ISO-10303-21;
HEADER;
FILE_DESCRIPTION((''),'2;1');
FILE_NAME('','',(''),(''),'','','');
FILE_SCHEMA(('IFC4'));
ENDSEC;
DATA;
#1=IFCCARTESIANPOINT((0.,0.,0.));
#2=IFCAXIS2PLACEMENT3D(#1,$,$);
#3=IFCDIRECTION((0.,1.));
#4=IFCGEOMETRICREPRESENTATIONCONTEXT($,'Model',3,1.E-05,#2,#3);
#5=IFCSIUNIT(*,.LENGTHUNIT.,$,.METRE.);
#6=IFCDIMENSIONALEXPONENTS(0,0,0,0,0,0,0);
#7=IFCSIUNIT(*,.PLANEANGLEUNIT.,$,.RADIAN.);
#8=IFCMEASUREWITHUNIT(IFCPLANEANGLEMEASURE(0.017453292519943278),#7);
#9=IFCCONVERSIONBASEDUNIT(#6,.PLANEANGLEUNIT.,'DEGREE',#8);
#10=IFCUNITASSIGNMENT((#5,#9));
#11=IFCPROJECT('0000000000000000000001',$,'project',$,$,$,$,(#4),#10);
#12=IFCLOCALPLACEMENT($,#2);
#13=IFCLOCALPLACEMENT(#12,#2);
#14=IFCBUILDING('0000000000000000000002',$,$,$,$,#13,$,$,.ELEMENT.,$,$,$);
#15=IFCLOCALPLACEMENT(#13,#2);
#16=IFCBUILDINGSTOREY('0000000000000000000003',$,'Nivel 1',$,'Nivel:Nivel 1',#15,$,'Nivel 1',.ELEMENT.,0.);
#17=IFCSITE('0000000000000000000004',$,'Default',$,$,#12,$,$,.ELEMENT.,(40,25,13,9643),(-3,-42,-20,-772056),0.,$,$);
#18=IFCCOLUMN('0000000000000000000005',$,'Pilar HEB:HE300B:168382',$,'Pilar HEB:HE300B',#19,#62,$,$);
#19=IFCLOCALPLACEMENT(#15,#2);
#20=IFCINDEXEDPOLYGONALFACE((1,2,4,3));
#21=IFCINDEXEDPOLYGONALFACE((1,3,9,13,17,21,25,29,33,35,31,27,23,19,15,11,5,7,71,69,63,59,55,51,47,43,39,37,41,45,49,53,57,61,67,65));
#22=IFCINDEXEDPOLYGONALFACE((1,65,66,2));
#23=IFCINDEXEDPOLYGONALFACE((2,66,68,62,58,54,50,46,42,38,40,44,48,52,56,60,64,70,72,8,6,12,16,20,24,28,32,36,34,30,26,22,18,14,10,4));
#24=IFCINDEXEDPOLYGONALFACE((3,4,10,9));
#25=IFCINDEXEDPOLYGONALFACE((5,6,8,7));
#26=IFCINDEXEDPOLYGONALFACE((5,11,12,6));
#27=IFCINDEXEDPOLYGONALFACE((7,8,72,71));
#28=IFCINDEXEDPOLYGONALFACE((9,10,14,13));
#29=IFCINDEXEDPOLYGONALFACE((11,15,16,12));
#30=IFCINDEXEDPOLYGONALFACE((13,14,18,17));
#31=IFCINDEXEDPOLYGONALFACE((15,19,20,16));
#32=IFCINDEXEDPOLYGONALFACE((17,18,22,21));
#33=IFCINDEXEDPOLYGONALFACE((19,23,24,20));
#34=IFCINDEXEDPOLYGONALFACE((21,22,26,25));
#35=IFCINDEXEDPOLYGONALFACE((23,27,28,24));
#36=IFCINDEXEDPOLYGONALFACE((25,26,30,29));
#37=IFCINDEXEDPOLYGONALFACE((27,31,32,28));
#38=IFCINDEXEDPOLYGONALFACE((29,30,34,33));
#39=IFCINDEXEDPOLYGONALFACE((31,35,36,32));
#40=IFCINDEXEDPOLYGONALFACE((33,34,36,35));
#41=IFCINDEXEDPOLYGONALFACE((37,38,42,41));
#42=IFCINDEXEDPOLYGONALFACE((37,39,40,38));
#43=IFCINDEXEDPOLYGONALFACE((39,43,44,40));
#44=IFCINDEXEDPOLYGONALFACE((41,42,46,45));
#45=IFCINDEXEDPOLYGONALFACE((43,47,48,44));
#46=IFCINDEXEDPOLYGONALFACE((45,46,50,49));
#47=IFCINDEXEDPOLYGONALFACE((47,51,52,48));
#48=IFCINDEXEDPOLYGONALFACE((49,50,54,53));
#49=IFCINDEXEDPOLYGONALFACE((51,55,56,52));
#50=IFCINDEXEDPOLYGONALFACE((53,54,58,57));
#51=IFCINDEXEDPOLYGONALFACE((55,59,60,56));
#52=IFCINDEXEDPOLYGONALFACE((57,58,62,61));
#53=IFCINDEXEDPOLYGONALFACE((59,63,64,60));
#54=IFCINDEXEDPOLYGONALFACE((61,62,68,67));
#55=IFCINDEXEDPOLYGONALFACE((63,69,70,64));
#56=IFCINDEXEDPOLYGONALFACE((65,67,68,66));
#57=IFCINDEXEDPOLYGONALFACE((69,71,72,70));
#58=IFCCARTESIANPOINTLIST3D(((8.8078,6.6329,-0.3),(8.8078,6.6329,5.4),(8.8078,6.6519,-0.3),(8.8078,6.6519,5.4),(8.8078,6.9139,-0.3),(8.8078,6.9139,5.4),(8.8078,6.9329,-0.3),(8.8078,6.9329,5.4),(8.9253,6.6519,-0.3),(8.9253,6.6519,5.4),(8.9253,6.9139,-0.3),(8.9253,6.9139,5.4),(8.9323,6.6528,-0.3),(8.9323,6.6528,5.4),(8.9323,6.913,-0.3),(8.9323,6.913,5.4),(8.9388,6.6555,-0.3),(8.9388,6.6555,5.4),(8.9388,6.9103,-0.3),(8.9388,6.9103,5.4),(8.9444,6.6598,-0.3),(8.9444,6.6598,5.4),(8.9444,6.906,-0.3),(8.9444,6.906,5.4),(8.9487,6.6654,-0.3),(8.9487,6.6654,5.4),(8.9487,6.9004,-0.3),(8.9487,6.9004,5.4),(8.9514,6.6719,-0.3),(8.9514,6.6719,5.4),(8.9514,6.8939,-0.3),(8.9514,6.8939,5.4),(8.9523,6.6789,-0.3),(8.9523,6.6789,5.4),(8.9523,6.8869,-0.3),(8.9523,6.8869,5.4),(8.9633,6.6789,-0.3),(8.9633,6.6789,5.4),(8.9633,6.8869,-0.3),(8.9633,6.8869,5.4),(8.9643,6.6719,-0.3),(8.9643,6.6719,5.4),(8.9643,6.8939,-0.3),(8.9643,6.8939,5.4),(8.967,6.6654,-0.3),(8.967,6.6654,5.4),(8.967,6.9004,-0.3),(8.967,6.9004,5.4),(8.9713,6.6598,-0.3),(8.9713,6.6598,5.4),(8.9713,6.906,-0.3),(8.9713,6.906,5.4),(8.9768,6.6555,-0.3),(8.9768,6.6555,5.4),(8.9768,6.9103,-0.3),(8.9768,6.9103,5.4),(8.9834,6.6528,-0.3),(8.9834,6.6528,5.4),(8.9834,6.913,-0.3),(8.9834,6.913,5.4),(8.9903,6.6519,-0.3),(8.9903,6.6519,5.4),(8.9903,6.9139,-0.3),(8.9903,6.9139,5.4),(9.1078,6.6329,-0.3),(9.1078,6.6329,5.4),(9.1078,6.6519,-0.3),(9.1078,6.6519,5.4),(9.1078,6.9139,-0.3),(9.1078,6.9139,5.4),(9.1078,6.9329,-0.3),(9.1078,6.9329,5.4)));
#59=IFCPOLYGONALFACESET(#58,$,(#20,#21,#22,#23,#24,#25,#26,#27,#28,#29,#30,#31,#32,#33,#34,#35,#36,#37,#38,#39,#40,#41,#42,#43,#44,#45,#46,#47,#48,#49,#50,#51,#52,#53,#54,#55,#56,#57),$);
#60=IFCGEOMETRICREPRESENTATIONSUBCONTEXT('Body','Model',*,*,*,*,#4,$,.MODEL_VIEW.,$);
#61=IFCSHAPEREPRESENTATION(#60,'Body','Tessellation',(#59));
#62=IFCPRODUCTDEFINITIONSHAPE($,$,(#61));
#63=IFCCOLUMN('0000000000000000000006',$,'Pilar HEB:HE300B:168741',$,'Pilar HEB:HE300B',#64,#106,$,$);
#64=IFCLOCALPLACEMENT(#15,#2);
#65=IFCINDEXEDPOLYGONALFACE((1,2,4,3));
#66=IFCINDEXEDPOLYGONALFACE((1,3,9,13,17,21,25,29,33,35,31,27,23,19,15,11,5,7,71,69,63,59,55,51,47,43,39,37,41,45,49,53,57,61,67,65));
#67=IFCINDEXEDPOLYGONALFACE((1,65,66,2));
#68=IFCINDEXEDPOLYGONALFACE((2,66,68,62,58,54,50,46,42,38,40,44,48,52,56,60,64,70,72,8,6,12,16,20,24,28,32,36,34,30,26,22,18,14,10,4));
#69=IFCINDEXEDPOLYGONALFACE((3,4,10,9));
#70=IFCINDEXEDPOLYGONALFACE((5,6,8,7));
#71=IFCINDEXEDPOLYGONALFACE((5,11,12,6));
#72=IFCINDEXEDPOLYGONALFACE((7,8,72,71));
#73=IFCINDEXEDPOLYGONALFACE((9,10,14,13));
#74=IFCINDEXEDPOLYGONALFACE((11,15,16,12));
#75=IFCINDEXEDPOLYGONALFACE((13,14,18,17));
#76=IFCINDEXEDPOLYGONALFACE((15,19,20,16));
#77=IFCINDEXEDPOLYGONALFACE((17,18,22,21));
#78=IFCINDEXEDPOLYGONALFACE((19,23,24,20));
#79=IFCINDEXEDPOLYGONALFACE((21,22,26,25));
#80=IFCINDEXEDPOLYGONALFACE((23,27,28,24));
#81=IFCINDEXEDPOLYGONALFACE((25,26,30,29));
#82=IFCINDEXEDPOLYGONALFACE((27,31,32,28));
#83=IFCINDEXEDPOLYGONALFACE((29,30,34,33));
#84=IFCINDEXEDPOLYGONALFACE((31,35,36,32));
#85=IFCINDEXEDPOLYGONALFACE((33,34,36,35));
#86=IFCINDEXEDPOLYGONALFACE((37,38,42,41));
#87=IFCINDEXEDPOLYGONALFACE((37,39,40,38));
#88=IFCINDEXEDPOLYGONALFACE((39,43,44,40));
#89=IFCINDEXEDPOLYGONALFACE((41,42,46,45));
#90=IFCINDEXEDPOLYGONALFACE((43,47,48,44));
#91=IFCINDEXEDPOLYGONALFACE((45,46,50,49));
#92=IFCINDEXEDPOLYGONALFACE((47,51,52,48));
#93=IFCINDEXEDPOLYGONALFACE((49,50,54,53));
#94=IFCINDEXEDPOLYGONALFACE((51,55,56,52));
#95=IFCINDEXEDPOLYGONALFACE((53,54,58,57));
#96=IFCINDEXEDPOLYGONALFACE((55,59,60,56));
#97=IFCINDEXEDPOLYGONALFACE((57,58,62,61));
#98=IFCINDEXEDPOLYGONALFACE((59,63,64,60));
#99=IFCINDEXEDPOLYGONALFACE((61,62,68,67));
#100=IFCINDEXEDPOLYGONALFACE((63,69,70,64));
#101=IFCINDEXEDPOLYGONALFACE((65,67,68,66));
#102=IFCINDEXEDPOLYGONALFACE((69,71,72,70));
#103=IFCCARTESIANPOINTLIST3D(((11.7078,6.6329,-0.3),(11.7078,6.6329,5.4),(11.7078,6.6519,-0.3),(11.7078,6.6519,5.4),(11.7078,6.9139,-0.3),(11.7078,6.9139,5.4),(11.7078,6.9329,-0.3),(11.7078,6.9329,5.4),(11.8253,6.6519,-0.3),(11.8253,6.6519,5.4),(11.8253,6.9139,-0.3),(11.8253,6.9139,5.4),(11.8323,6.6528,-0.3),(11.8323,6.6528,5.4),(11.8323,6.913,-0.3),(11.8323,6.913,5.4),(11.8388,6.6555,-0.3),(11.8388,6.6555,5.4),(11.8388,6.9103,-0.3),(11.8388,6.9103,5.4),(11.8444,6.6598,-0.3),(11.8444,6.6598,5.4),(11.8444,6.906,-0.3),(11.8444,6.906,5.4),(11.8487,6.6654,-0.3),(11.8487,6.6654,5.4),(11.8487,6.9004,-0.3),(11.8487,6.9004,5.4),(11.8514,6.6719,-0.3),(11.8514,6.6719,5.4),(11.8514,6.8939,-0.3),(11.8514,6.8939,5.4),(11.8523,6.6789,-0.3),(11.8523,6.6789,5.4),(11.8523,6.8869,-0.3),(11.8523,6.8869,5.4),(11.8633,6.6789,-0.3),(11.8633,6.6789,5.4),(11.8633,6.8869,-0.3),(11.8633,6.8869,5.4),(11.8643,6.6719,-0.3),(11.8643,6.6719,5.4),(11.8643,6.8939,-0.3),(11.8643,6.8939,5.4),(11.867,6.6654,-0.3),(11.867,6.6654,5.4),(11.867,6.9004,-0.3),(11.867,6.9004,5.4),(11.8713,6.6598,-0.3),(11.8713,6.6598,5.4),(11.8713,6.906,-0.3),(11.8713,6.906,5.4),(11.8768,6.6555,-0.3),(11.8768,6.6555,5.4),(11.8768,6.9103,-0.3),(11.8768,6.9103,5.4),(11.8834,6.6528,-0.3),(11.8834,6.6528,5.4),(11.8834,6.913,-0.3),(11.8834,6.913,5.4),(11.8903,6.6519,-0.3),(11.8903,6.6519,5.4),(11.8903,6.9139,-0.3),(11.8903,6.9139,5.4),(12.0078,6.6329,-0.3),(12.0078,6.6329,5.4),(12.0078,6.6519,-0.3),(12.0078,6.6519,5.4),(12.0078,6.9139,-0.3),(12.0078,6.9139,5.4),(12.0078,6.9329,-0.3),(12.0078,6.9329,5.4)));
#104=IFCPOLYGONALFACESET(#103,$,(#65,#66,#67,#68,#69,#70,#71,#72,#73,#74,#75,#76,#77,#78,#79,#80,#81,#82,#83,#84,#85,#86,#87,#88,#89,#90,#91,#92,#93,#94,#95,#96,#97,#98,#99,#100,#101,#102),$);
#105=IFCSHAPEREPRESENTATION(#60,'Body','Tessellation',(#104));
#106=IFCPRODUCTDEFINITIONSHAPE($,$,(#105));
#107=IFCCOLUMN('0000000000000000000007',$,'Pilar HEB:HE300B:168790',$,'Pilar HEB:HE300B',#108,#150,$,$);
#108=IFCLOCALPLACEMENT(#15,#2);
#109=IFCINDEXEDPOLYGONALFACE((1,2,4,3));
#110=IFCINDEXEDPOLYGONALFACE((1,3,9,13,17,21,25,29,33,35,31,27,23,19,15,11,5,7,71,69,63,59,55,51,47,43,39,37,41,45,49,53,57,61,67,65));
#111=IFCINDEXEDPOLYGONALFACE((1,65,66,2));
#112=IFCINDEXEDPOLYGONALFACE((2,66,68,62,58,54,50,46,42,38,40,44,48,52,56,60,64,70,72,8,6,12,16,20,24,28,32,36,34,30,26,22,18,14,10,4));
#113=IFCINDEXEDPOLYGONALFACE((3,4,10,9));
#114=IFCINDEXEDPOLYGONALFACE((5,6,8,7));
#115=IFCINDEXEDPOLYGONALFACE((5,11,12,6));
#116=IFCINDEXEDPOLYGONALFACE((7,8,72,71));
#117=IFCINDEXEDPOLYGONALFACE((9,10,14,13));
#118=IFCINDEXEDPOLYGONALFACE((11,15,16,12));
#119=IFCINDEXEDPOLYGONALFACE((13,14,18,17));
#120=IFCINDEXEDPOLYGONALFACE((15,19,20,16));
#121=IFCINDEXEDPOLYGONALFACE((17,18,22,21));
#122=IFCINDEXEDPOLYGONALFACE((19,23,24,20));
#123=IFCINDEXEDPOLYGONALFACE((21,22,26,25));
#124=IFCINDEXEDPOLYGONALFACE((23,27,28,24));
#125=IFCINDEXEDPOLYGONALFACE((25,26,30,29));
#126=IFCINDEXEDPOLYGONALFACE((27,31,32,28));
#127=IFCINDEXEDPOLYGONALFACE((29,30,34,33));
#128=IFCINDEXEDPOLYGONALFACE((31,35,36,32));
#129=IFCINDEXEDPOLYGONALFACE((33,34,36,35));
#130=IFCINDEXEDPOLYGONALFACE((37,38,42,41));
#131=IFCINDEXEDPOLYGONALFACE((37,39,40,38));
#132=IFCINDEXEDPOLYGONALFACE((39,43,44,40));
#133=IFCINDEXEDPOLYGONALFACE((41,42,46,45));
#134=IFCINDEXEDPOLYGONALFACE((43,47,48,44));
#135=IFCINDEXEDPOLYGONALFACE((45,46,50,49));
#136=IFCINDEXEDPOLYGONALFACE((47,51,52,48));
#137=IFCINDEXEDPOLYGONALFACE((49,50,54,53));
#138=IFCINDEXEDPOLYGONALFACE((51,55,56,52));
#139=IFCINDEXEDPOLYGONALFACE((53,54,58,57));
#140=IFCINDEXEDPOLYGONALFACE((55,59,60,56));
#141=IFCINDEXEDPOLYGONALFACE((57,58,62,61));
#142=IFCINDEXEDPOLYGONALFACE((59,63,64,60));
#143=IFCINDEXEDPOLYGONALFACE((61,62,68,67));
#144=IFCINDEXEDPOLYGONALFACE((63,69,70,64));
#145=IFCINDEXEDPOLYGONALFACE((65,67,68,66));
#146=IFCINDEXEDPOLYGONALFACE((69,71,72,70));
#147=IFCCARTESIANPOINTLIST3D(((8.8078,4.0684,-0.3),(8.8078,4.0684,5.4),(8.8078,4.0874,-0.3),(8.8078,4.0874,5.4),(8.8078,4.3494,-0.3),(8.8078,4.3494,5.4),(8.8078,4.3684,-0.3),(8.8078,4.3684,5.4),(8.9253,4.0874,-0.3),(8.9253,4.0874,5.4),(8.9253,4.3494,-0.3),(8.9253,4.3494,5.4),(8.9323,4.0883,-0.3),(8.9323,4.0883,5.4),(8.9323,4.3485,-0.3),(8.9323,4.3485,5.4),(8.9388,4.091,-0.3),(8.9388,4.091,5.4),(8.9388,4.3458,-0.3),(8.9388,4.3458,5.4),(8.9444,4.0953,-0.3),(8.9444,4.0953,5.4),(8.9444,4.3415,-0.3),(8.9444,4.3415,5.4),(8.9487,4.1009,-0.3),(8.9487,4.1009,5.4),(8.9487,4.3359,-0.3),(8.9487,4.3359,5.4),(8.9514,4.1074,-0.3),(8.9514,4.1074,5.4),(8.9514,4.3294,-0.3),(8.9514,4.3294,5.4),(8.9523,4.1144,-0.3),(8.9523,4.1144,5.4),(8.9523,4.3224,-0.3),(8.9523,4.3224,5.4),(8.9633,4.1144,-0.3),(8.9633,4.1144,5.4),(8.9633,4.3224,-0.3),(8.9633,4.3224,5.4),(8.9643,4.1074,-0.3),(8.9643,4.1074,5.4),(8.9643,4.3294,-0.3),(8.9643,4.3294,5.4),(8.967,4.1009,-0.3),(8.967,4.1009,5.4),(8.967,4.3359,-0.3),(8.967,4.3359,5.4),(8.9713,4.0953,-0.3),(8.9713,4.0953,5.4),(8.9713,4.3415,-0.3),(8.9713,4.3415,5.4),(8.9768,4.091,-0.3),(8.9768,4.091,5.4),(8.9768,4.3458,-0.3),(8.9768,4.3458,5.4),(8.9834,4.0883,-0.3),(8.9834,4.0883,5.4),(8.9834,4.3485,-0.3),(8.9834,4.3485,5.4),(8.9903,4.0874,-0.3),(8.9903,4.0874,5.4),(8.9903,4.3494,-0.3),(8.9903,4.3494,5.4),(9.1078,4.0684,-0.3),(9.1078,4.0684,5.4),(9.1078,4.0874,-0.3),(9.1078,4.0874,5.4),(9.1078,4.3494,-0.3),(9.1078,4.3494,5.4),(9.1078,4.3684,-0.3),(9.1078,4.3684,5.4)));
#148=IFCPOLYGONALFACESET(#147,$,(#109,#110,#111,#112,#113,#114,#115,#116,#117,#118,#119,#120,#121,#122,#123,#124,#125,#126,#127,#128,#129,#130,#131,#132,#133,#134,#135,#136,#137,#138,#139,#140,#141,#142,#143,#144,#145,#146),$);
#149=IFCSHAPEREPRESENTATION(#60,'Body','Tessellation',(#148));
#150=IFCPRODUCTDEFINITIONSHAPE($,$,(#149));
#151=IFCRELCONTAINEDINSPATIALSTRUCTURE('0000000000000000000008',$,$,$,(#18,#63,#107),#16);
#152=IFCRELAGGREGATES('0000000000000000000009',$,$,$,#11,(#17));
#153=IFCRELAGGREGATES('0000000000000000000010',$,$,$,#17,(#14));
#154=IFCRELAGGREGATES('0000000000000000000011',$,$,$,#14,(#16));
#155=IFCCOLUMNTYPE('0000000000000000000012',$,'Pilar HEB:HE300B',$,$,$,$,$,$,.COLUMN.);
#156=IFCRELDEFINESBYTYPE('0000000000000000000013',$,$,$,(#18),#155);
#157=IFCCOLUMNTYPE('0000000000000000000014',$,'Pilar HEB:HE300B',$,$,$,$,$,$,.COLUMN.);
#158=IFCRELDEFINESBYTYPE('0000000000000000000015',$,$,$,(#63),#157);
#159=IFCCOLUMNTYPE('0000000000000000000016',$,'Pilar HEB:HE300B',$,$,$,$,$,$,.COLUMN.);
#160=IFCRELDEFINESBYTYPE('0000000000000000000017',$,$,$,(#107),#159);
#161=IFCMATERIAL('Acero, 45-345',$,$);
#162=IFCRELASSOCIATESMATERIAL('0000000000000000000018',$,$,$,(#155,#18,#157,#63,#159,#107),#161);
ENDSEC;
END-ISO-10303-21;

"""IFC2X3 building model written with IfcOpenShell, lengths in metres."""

from ifc_helpers import new_model, entity, si_unit, converted_unit, direction, frame, frame_2d, origin, place, context, subcontext, project, spatial, i_section, extrude, source, transform, mapped, material, type_object, type_shapes, element, save


model = new_model("IFC2X3")

# Units and contexts
model_context = context("Model", 3, precision=1e-05, world=origin(), true_north=direction((0.0, 1.0)))
body_context = subcontext(model_context, "Body", "Model", "MODEL_VIEW")
ifc_project = project(units=[si_unit("LENGTHUNIT", "METRE"), converted_unit("PLANEANGLEUNIT", "DEGREE", entity("IfcPlaneAngleMeasure", 0.017453292519943278), si_unit("PLANEANGLEUNIT", "RADIAN"), dimensions=[0, 0, 0, 0, 0, 0, 0])], contexts=[model_context])

# Site, building, storey
site_placement = place(None, origin())
site = spatial("IfcSite", under=ifc_project, at=site_placement, Name="Default", CompositionType="ELEMENT", RefLatitude=(40, 25, 13, 9643), RefLongitude=(-3, -42, -20, -772056), RefElevation=0.0)
building_placement = place(site_placement, origin())
building = spatial("IfcBuilding", under=site, at=building_placement, CompositionType="ELEMENT")
storey_placement = place(building_placement, origin())
storey = spatial("IfcBuildingStorey", under=building, at=storey_placement, Name="Nivel 1", ObjectType="Nivel:Nivel 1", LongName="Nivel 1", CompositionType="ELEMENT", Elevation=0.0)

# Columns
ifc_material_1 = material(Name="Acero, 45-345")
column_type_1 = type_object("IfcColumnType", Name="Pilar HEB:HE300B", PredefinedType="COLUMN", material=ifc_material_1)
shared_shape_1 = source(origin(), body_context, "Body", "SweptSolid", [
    extrude(i_section(OverallWidth=0.3, OverallDepth=0.3, WebThickness=0.011, FlangeThickness=0.019, FilletRadius=0.027, at=frame_2d((0.0, 0.0), x_axis=(1.0, 0.0))), frame((8.9578, 6.7829, -0.3), z_axis=(0.0, 0.0, 1.0), x_axis=(-1.0, 0.0, 0.0)), (0.0, 0.0, 1.0), 5.7),
])
type_shapes(column_type_1, [shared_shape_1])
column_1_placement = place(storey_placement, origin())
element("IfcColumn", 1, at=column_1_placement, inside=storey, type_object=column_type_1, material=ifc_material_1, Name="Pilar HEB:HE300B:168382", ObjectType="Pilar HEB:HE300B", context=body_context, shape_type="MappedRepresentation", body=[
    mapped(shared_shape_1, transform((0.0, 0.0, 0.0), scale=1.0)),
])
column_type_2 = type_object("IfcColumnType", Name="Pilar HEB:HE300B", PredefinedType="COLUMN", material=ifc_material_1)
shared_shape_2 = source(origin(), body_context, "Body", "SweptSolid", [
    extrude(i_section(OverallWidth=0.3, OverallDepth=0.3, WebThickness=0.011, FlangeThickness=0.019, FilletRadius=0.027, at=frame_2d((0.0, 0.0), x_axis=(1.0, 0.0))), frame((11.8578, 6.7829, -0.3), z_axis=(0.0, 0.0, 1.0), x_axis=(-1.0, 0.0, 0.0)), (0.0, 0.0, 1.0), 5.7),
])
type_shapes(column_type_2, [shared_shape_2])
column_2_placement = place(storey_placement, origin())
element("IfcColumn", 2, at=column_2_placement, inside=storey, type_object=column_type_2, material=ifc_material_1, Name="Pilar HEB:HE300B:168741", ObjectType="Pilar HEB:HE300B", context=body_context, shape_type="MappedRepresentation", body=[
    mapped(shared_shape_2, transform((0.0, 0.0, 0.0), scale=1.0)),
])
column_type_3 = type_object("IfcColumnType", Name="Pilar HEB:HE300B", PredefinedType="COLUMN", material=ifc_material_1)
shared_shape_3 = source(origin(), body_context, "Body", "SweptSolid", [
    extrude(i_section(OverallWidth=0.3, OverallDepth=0.3, WebThickness=0.011, FlangeThickness=0.019, FilletRadius=0.027, at=frame_2d((0.0, 0.0), x_axis=(1.0, 0.0))), frame((8.9578, 4.2184, -0.3), z_axis=(0.0, 0.0, 1.0), x_axis=(-1.0, 0.0, 0.0)), (0.0, 0.0, 1.0), 5.7),
])
type_shapes(column_type_3, [shared_shape_3])
column_3_placement = place(storey_placement, origin())
element("IfcColumn", 3, at=column_3_placement, inside=storey, type_object=column_type_3, material=ifc_material_1, Name="Pilar HEB:HE300B:168790", ObjectType="Pilar HEB:HE300B", context=body_context, shape_type="MappedRepresentation", body=[
    mapped(shared_shape_3, transform((0.0, 0.0, 0.0), scale=1.0)),
])

save(model, "model.ifc")
